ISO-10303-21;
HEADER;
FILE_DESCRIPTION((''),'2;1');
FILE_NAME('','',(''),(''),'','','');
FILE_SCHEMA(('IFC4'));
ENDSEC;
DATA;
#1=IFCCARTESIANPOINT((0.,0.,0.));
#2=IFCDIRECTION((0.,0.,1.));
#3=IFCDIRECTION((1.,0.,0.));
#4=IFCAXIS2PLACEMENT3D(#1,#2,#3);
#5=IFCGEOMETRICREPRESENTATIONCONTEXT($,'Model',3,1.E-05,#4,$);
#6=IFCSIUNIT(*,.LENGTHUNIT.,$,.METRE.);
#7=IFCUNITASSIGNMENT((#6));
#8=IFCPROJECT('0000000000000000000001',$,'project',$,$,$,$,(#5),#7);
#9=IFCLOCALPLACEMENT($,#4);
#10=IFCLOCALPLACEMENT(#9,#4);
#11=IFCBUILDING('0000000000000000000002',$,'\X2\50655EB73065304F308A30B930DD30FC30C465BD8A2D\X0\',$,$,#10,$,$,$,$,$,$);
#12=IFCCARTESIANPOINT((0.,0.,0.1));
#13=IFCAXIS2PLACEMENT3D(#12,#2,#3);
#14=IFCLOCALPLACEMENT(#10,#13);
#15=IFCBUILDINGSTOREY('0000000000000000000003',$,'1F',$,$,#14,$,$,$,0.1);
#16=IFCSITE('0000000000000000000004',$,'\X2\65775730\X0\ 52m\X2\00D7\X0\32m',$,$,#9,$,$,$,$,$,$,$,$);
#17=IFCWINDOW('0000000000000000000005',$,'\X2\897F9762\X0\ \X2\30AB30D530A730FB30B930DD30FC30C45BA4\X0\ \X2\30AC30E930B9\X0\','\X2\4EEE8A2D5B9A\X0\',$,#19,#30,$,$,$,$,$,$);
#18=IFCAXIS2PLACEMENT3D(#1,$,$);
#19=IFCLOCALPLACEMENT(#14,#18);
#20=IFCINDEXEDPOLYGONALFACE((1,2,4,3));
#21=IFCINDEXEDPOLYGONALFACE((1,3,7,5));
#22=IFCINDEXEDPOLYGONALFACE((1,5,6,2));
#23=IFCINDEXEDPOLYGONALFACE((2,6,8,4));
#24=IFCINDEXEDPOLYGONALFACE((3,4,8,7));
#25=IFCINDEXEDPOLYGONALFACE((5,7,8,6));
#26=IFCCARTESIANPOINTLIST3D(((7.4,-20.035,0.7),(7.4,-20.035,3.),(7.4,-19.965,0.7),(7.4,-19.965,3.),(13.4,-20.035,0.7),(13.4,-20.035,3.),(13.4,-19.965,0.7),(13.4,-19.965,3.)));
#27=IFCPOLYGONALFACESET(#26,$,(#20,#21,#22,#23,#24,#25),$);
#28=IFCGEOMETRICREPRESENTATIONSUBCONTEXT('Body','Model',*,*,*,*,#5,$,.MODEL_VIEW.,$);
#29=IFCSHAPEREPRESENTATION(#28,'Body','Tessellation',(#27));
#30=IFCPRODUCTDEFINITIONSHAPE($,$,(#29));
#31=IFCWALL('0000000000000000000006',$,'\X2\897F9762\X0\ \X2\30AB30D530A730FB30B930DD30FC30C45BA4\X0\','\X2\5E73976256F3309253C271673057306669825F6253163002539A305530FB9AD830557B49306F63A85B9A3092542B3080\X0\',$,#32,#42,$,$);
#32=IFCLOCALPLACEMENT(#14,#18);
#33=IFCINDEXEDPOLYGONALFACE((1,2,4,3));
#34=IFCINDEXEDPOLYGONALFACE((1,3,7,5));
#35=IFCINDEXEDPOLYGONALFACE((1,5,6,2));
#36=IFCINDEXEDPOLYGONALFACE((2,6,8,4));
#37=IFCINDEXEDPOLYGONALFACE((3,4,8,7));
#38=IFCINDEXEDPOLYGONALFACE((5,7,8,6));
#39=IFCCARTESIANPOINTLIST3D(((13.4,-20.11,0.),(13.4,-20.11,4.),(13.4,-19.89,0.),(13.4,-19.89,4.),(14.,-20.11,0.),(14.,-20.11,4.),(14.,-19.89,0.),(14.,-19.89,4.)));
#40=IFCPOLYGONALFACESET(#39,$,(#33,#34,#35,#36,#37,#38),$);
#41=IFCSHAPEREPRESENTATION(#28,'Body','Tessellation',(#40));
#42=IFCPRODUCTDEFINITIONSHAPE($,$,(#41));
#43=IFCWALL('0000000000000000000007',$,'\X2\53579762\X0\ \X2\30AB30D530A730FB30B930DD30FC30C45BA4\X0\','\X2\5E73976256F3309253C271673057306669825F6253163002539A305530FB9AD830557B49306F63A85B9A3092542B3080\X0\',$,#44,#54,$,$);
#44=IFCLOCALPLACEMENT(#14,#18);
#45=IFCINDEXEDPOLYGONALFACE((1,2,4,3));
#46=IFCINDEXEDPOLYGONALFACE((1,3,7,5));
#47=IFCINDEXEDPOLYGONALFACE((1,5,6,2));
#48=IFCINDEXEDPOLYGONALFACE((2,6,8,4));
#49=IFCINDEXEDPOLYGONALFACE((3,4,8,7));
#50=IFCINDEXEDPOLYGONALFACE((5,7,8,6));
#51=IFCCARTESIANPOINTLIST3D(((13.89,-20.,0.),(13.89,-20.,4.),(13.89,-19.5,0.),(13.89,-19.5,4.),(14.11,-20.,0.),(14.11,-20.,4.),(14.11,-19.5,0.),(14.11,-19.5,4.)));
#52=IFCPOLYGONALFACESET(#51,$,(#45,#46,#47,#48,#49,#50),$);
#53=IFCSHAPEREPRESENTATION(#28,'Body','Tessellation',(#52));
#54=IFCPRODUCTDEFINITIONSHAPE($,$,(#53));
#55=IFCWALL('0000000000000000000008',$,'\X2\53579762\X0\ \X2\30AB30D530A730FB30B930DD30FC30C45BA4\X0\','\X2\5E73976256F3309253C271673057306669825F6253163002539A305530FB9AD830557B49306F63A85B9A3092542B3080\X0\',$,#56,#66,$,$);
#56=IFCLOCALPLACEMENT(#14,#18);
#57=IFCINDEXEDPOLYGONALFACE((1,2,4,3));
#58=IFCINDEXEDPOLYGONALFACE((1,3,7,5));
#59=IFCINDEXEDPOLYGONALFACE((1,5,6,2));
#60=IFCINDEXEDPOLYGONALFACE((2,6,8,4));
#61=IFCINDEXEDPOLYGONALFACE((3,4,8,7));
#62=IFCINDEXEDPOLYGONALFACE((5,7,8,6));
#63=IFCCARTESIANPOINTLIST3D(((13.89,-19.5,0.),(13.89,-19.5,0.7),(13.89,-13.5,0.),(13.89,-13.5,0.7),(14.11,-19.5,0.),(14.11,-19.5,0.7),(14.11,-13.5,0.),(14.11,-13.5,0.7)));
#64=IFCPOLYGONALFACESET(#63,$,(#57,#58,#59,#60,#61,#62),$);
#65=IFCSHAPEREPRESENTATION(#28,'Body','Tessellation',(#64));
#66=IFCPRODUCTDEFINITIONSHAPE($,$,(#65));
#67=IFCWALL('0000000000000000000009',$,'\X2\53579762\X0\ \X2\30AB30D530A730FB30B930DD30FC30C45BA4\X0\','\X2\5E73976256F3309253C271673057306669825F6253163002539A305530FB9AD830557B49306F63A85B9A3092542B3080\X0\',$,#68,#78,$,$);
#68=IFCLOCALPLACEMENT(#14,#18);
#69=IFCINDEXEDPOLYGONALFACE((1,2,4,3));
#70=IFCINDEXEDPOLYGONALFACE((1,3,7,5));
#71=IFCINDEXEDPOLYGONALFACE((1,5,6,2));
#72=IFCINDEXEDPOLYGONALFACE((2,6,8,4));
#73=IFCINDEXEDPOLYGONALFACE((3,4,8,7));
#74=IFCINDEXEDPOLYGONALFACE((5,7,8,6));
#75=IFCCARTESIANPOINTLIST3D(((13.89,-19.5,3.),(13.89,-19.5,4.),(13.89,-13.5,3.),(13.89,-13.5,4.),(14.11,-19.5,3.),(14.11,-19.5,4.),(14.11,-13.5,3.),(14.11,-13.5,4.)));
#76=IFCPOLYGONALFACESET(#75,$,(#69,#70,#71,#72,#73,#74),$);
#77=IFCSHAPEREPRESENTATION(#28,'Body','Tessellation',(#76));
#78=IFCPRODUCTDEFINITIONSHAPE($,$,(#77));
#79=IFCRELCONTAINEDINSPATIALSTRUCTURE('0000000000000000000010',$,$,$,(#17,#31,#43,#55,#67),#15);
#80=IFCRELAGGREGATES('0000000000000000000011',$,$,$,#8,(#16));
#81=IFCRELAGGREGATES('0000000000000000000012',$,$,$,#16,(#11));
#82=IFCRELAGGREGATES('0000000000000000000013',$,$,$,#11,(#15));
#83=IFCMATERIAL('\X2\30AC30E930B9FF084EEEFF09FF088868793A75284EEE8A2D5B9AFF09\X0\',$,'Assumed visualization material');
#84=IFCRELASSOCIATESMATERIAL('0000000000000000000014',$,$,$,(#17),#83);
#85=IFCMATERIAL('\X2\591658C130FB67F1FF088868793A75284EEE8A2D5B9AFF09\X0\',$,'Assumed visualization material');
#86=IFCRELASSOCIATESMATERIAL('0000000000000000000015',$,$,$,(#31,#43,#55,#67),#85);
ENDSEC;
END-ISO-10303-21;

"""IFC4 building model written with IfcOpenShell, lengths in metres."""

from ifc_helpers import new_model, si_unit, frame, origin_with_axes, place, context, subcontext, project, spatial, rectangle, extrude, material, element, save


model = new_model("IFC4")

# Units and contexts
model_context = context("Model", 3, precision=1e-05, world=origin_with_axes())
body_context = subcontext(model_context, "Body", "Model", "MODEL_VIEW")
ifc_project = project(units=[si_unit("LENGTHUNIT", "METRE")], contexts=[model_context])

# Site, building, storey
site_placement = place(None, origin_with_axes())
site = spatial("IfcSite", under=ifc_project, at=site_placement, Name="敷地 52m×32m")
building_placement = place(site_placement, origin_with_axes())
building = spatial("IfcBuilding", under=site, at=building_placement, Name="健康づくりスポーツ施設")
storey_placement = place(building_placement, frame((0.0, 0.0, 0.1), z_axis=(0.0, 0.0, 1.0), x_axis=(1.0, 0.0, 0.0)))
storey = spatial("IfcBuildingStorey", under=building, at=storey_placement, Name="1F", Elevation=0.1)

# Shared definitions
ifc_material_1 = material(Name="外壁・柱（表示用仮設定）", Category="Assumed visualization material")

# Window
ifc_material_2 = material(Name="ガラス（仮）（表示用仮設定）", Category="Assumed visualization material")
window_placement = place(storey_placement, frame((10.4, -20.0, 0.7), z_axis=(0.0, 0.0, 1.0), x_axis=(1.0, 0.0, 0.0)))
element("IfcWindow", 1, at=window_placement, inside=storey, material=ifc_material_2, Name="西面 カフェ・スポーツ室 ガラス", Description="仮設定", context=body_context, shape_type="SweptSolid", body=[
    extrude(rectangle(XDim=6.0, YDim=0.07), origin_with_axes(), (0.0, 0.0, 1.0), 2.3),
])

# Walls
wall_1_placement = place(storey_placement, frame((13.7, -20.0, 0.0), z_axis=(0.0, 0.0, 1.0), x_axis=(1.0, 0.0, 0.0)))
element("IfcWall", 2, at=wall_1_placement, inside=storey, material=ifc_material_1, Name="西面 カフェ・スポーツ室", Description="平面図を参照して概形化。厚さ・高さ等は推定を含む", context=body_context, shape_type="SweptSolid", body=[
    extrude(rectangle(XDim=0.6, YDim=0.22), origin_with_axes(), (0.0, 0.0, 1.0), 4.0),
])
wall_2_placement = place(storey_placement, frame((14.0, -19.75, 0.0), z_axis=(0.0, 0.0, 1.0), x_axis=(1.0, 0.0, 0.0)))
element("IfcWall", 3, at=wall_2_placement, inside=storey, material=ifc_material_1, Name="南面 カフェ・スポーツ室", Description="平面図を参照して概形化。厚さ・高さ等は推定を含む", context=body_context, shape_type="SweptSolid", body=[
    extrude(rectangle(XDim=0.22, YDim=0.5), origin_with_axes(), (0.0, 0.0, 1.0), 4.0),
])
wall_3_placement = place(storey_placement, frame((14.0, -16.5, 0.0), z_axis=(0.0, 0.0, 1.0), x_axis=(1.0, 0.0, 0.0)))
element("IfcWall", 4, at=wall_3_placement, inside=storey, material=ifc_material_1, Name="南面 カフェ・スポーツ室", Description="平面図を参照して概形化。厚さ・高さ等は推定を含む", context=body_context, shape_type="SweptSolid", body=[
    extrude(rectangle(XDim=0.22, YDim=6.0), origin_with_axes(), (0.0, 0.0, 1.0), 0.7),
])
wall_4_placement = place(storey_placement, frame((14.0, -16.5, 3.0), z_axis=(0.0, 0.0, 1.0), x_axis=(1.0, 0.0, 0.0)))
element("IfcWall", 5, at=wall_4_placement, inside=storey, material=ifc_material_1, Name="南面 カフェ・スポーツ室", Description="平面図を参照して概形化。厚さ・高さ等は推定を含む", context=body_context, shape_type="SweptSolid", body=[
    extrude(rectangle(XDim=0.22, YDim=6.0), origin_with_axes(), (0.0, 0.0, 1.0), 1.0),
])

save(model, "model.ifc")
